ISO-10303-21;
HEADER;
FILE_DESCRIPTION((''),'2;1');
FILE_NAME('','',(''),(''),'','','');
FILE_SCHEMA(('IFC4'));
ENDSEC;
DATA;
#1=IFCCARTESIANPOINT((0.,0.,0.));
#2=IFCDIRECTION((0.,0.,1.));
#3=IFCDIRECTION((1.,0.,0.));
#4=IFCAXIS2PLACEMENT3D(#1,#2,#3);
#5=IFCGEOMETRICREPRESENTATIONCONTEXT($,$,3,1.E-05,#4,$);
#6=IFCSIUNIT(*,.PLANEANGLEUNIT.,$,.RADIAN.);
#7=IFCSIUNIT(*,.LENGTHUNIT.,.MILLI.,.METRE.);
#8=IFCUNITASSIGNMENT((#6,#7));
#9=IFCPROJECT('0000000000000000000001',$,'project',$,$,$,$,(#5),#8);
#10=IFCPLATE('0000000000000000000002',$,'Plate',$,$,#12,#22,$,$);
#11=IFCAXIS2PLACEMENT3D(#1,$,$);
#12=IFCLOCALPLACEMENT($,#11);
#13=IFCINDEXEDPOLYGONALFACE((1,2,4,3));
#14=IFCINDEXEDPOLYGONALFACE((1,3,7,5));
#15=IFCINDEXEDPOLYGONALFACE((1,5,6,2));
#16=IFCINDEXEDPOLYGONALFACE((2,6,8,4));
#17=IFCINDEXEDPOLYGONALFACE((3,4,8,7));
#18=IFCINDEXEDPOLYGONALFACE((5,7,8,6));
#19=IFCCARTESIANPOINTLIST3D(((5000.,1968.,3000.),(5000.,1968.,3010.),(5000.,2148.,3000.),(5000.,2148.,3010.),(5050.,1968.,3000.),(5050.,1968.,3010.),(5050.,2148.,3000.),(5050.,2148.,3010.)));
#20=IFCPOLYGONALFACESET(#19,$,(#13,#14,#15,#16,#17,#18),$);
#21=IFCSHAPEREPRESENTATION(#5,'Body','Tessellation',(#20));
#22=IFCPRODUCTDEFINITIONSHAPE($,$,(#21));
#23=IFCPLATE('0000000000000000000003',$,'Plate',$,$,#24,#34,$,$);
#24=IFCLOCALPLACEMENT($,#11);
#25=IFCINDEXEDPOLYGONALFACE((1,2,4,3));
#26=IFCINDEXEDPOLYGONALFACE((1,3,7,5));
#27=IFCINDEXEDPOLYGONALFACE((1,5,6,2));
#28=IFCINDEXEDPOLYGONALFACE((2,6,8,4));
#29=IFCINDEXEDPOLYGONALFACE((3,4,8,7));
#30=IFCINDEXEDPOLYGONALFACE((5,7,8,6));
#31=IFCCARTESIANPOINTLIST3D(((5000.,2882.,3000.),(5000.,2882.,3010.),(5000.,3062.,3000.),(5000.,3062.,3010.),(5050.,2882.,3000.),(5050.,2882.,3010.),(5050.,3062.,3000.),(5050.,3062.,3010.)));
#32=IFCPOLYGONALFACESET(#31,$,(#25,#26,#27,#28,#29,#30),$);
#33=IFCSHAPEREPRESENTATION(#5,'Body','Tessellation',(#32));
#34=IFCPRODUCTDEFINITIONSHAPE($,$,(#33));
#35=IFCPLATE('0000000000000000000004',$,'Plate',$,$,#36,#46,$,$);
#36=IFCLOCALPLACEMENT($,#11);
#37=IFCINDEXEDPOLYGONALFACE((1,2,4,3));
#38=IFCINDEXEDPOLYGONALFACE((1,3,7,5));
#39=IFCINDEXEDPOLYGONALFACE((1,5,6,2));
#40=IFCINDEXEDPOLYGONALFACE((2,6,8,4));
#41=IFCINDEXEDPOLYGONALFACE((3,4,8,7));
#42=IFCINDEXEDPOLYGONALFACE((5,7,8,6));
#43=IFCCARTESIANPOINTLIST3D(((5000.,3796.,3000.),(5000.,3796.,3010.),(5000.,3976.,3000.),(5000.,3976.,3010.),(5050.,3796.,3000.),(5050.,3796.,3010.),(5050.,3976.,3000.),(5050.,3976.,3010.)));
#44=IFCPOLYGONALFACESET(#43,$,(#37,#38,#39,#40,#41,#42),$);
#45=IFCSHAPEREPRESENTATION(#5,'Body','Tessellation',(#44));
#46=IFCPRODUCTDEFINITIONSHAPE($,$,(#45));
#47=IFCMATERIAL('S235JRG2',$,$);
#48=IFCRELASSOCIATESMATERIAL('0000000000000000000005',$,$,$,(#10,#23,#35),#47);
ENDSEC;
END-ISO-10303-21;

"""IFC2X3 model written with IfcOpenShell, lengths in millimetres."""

from ifc_helpers import new_model, si_unit, frame, origin_with_axes, place, context, project, polyline, outline, extrude, material, element, save


model = new_model("IFC2X3")

# Units and contexts
context_of_model = context(None, 3, precision=1e-05, world=origin_with_axes())
ifc_project = project(units=[si_unit("PLANEANGLEUNIT", "RADIAN"), si_unit("LENGTHUNIT", "METRE", prefix="MILLI")], contexts=[context_of_model])

# Shared definitions
ifc_material = material(Name="S235JRG2")

# Plates
placement_1 = place(None, origin_with_axes())
plate_1_placement = place(placement_1, frame((5000.0, 1968.0, 3010.0), z_axis=(1.0, 0.0, 0.0), x_axis=(0.0, 0.0, -1.0)))
element("IfcPlate", 1, at=plate_1_placement, material=ifc_material, Name="Plate", context=context_of_model, shape_type="SweptSolid", body=[
    extrude(outline(polyline([(0.0, 0.0), (180.0, 0.0), (180.0, 50.0), (0.0, 50.0), (0.0, 0.0)])), frame((0.0, 0.0, 0.0), z_axis=(1.0, 0.0, 0.0), x_axis=(0.0, 1.0, 0.0)), (0.0, 0.0, 1.0), 10.0),
])
placement_2 = place(None, origin_with_axes())
plate_2_placement = place(placement_2, frame((5000.0, 2882.0, 3010.0), z_axis=(1.0, 0.0, 0.0), x_axis=(0.0, 0.0, -1.0)))
element("IfcPlate", 2, at=plate_2_placement, material=ifc_material, Name="Plate", context=context_of_model, shape_type="SweptSolid", body=[
    extrude(outline(polyline([(0.0, 0.0), (180.0, 0.0), (180.0, 50.0), (0.0, 50.0), (0.0, 0.0)])), frame((0.0, 0.0, 0.0), z_axis=(1.0, 0.0, 0.0), x_axis=(0.0, 1.0, 0.0)), (0.0, 0.0, 1.0), 10.0),
])
placement_3 = place(None, origin_with_axes())
plate_3_placement = place(placement_3, frame((5000.0, 3796.0, 3010.0), z_axis=(1.0, 0.0, 0.0), x_axis=(0.0, 0.0, -1.0)))
element("IfcPlate", 3, at=plate_3_placement, material=ifc_material, Name="Plate", context=context_of_model, shape_type="SweptSolid", body=[
    extrude(outline(polyline([(0.0, 0.0), (180.0, 0.0), (180.0, 50.0), (0.0, 50.0), (0.0, 0.0)])), frame((0.0, 0.0, 0.0), z_axis=(1.0, 0.0, 0.0), x_axis=(0.0, 1.0, 0.0)), (0.0, 0.0, 1.0), 10.0),
])

save(model, "model.ifc")
